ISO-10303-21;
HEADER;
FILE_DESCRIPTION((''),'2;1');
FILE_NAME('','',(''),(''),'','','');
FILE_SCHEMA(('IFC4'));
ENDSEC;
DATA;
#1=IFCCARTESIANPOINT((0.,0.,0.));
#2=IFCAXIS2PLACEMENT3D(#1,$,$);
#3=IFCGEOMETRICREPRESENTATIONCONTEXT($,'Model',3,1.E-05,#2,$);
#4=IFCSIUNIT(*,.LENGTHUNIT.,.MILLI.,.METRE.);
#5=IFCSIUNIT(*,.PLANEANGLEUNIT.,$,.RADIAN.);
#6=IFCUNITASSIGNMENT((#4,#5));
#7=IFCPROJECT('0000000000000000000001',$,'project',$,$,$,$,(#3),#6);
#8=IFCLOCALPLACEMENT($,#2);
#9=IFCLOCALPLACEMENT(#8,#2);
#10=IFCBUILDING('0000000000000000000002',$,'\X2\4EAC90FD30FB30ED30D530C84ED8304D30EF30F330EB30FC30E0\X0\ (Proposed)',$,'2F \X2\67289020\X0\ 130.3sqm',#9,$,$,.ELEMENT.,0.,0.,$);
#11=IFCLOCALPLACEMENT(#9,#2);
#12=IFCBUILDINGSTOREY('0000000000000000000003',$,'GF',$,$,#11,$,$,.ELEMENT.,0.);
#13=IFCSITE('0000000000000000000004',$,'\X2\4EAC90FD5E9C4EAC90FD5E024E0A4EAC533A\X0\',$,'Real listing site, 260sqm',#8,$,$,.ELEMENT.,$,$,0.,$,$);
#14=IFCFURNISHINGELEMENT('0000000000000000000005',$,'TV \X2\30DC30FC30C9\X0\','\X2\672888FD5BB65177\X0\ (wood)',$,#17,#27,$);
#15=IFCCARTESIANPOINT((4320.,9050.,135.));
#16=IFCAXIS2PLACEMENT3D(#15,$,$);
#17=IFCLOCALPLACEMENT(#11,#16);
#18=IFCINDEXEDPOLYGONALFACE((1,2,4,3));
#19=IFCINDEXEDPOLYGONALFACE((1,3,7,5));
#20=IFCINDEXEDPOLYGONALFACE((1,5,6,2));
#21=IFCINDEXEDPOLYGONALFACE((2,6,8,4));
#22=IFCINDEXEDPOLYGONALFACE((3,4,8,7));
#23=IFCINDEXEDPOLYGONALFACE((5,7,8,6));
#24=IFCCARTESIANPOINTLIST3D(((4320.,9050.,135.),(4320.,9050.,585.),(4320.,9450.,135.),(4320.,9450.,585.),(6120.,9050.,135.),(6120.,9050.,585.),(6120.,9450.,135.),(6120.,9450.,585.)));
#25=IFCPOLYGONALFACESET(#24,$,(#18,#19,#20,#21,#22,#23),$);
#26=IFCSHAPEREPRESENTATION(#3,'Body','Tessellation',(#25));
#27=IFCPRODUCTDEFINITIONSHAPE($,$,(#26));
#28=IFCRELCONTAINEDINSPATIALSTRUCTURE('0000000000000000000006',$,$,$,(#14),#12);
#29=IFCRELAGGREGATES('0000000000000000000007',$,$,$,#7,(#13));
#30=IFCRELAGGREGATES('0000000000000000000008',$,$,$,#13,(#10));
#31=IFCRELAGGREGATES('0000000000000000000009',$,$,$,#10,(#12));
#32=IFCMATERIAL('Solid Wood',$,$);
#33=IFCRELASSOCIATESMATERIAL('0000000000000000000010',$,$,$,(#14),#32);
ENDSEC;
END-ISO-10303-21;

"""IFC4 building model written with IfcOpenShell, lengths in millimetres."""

from ifc_helpers import new_model, si_unit, frame, frame_2d, origin, place, context, project, spatial, rectangle, extrude, material, element, save


model = new_model("IFC4")

# Units and contexts
model_context = context("Model", 3, precision=1e-05, world=origin())
ifc_project = project(units=[si_unit("LENGTHUNIT", "METRE", prefix="MILLI"), si_unit("PLANEANGLEUNIT", "RADIAN")], contexts=[model_context])

# Site, building, storey
site_placement = place(None, origin())
site = spatial("IfcSite", under=ifc_project, at=site_placement, Name="京都府京都市上京区", ObjectType="Real listing site, 260sqm", CompositionType="ELEMENT", RefElevation=0.0)
building_placement = place(site_placement, origin())
building = spatial("IfcBuilding", under=site, at=building_placement, Name="京都・ロフト付きワンルーム (Proposed)", ObjectType="2F 木造 130.3sqm", CompositionType="ELEMENT", ElevationOfRefHeight=0.0, ElevationOfTerrain=0.0)
storey_placement = place(building_placement, origin())
storey = spatial("IfcBuildingStorey", under=building, at=storey_placement, Name="GF", CompositionType="ELEMENT", Elevation=0.0)

# Shared definitions
ifc_material_1 = material(Name="Solid Wood")

# Furnishing element
furnishing_placement = place(storey_placement, frame((4320.0, 9050.0, 135.0)))
element("IfcFurnishingElement", 1, at=furnishing_placement, inside=storey, material=ifc_material_1, Name="TV ボード", Description="木製家具 (wood)", context=model_context, shape_type="SweptSolid", body=[
    extrude(rectangle(XDim=1800.0, YDim=400.0, at=frame_2d((900.0, 200.0))), frame((4320.0, 9050.0, 135.0)), (0.0, 0.0, 1.0), 450.0),
])

save(model, "model.ifc")
